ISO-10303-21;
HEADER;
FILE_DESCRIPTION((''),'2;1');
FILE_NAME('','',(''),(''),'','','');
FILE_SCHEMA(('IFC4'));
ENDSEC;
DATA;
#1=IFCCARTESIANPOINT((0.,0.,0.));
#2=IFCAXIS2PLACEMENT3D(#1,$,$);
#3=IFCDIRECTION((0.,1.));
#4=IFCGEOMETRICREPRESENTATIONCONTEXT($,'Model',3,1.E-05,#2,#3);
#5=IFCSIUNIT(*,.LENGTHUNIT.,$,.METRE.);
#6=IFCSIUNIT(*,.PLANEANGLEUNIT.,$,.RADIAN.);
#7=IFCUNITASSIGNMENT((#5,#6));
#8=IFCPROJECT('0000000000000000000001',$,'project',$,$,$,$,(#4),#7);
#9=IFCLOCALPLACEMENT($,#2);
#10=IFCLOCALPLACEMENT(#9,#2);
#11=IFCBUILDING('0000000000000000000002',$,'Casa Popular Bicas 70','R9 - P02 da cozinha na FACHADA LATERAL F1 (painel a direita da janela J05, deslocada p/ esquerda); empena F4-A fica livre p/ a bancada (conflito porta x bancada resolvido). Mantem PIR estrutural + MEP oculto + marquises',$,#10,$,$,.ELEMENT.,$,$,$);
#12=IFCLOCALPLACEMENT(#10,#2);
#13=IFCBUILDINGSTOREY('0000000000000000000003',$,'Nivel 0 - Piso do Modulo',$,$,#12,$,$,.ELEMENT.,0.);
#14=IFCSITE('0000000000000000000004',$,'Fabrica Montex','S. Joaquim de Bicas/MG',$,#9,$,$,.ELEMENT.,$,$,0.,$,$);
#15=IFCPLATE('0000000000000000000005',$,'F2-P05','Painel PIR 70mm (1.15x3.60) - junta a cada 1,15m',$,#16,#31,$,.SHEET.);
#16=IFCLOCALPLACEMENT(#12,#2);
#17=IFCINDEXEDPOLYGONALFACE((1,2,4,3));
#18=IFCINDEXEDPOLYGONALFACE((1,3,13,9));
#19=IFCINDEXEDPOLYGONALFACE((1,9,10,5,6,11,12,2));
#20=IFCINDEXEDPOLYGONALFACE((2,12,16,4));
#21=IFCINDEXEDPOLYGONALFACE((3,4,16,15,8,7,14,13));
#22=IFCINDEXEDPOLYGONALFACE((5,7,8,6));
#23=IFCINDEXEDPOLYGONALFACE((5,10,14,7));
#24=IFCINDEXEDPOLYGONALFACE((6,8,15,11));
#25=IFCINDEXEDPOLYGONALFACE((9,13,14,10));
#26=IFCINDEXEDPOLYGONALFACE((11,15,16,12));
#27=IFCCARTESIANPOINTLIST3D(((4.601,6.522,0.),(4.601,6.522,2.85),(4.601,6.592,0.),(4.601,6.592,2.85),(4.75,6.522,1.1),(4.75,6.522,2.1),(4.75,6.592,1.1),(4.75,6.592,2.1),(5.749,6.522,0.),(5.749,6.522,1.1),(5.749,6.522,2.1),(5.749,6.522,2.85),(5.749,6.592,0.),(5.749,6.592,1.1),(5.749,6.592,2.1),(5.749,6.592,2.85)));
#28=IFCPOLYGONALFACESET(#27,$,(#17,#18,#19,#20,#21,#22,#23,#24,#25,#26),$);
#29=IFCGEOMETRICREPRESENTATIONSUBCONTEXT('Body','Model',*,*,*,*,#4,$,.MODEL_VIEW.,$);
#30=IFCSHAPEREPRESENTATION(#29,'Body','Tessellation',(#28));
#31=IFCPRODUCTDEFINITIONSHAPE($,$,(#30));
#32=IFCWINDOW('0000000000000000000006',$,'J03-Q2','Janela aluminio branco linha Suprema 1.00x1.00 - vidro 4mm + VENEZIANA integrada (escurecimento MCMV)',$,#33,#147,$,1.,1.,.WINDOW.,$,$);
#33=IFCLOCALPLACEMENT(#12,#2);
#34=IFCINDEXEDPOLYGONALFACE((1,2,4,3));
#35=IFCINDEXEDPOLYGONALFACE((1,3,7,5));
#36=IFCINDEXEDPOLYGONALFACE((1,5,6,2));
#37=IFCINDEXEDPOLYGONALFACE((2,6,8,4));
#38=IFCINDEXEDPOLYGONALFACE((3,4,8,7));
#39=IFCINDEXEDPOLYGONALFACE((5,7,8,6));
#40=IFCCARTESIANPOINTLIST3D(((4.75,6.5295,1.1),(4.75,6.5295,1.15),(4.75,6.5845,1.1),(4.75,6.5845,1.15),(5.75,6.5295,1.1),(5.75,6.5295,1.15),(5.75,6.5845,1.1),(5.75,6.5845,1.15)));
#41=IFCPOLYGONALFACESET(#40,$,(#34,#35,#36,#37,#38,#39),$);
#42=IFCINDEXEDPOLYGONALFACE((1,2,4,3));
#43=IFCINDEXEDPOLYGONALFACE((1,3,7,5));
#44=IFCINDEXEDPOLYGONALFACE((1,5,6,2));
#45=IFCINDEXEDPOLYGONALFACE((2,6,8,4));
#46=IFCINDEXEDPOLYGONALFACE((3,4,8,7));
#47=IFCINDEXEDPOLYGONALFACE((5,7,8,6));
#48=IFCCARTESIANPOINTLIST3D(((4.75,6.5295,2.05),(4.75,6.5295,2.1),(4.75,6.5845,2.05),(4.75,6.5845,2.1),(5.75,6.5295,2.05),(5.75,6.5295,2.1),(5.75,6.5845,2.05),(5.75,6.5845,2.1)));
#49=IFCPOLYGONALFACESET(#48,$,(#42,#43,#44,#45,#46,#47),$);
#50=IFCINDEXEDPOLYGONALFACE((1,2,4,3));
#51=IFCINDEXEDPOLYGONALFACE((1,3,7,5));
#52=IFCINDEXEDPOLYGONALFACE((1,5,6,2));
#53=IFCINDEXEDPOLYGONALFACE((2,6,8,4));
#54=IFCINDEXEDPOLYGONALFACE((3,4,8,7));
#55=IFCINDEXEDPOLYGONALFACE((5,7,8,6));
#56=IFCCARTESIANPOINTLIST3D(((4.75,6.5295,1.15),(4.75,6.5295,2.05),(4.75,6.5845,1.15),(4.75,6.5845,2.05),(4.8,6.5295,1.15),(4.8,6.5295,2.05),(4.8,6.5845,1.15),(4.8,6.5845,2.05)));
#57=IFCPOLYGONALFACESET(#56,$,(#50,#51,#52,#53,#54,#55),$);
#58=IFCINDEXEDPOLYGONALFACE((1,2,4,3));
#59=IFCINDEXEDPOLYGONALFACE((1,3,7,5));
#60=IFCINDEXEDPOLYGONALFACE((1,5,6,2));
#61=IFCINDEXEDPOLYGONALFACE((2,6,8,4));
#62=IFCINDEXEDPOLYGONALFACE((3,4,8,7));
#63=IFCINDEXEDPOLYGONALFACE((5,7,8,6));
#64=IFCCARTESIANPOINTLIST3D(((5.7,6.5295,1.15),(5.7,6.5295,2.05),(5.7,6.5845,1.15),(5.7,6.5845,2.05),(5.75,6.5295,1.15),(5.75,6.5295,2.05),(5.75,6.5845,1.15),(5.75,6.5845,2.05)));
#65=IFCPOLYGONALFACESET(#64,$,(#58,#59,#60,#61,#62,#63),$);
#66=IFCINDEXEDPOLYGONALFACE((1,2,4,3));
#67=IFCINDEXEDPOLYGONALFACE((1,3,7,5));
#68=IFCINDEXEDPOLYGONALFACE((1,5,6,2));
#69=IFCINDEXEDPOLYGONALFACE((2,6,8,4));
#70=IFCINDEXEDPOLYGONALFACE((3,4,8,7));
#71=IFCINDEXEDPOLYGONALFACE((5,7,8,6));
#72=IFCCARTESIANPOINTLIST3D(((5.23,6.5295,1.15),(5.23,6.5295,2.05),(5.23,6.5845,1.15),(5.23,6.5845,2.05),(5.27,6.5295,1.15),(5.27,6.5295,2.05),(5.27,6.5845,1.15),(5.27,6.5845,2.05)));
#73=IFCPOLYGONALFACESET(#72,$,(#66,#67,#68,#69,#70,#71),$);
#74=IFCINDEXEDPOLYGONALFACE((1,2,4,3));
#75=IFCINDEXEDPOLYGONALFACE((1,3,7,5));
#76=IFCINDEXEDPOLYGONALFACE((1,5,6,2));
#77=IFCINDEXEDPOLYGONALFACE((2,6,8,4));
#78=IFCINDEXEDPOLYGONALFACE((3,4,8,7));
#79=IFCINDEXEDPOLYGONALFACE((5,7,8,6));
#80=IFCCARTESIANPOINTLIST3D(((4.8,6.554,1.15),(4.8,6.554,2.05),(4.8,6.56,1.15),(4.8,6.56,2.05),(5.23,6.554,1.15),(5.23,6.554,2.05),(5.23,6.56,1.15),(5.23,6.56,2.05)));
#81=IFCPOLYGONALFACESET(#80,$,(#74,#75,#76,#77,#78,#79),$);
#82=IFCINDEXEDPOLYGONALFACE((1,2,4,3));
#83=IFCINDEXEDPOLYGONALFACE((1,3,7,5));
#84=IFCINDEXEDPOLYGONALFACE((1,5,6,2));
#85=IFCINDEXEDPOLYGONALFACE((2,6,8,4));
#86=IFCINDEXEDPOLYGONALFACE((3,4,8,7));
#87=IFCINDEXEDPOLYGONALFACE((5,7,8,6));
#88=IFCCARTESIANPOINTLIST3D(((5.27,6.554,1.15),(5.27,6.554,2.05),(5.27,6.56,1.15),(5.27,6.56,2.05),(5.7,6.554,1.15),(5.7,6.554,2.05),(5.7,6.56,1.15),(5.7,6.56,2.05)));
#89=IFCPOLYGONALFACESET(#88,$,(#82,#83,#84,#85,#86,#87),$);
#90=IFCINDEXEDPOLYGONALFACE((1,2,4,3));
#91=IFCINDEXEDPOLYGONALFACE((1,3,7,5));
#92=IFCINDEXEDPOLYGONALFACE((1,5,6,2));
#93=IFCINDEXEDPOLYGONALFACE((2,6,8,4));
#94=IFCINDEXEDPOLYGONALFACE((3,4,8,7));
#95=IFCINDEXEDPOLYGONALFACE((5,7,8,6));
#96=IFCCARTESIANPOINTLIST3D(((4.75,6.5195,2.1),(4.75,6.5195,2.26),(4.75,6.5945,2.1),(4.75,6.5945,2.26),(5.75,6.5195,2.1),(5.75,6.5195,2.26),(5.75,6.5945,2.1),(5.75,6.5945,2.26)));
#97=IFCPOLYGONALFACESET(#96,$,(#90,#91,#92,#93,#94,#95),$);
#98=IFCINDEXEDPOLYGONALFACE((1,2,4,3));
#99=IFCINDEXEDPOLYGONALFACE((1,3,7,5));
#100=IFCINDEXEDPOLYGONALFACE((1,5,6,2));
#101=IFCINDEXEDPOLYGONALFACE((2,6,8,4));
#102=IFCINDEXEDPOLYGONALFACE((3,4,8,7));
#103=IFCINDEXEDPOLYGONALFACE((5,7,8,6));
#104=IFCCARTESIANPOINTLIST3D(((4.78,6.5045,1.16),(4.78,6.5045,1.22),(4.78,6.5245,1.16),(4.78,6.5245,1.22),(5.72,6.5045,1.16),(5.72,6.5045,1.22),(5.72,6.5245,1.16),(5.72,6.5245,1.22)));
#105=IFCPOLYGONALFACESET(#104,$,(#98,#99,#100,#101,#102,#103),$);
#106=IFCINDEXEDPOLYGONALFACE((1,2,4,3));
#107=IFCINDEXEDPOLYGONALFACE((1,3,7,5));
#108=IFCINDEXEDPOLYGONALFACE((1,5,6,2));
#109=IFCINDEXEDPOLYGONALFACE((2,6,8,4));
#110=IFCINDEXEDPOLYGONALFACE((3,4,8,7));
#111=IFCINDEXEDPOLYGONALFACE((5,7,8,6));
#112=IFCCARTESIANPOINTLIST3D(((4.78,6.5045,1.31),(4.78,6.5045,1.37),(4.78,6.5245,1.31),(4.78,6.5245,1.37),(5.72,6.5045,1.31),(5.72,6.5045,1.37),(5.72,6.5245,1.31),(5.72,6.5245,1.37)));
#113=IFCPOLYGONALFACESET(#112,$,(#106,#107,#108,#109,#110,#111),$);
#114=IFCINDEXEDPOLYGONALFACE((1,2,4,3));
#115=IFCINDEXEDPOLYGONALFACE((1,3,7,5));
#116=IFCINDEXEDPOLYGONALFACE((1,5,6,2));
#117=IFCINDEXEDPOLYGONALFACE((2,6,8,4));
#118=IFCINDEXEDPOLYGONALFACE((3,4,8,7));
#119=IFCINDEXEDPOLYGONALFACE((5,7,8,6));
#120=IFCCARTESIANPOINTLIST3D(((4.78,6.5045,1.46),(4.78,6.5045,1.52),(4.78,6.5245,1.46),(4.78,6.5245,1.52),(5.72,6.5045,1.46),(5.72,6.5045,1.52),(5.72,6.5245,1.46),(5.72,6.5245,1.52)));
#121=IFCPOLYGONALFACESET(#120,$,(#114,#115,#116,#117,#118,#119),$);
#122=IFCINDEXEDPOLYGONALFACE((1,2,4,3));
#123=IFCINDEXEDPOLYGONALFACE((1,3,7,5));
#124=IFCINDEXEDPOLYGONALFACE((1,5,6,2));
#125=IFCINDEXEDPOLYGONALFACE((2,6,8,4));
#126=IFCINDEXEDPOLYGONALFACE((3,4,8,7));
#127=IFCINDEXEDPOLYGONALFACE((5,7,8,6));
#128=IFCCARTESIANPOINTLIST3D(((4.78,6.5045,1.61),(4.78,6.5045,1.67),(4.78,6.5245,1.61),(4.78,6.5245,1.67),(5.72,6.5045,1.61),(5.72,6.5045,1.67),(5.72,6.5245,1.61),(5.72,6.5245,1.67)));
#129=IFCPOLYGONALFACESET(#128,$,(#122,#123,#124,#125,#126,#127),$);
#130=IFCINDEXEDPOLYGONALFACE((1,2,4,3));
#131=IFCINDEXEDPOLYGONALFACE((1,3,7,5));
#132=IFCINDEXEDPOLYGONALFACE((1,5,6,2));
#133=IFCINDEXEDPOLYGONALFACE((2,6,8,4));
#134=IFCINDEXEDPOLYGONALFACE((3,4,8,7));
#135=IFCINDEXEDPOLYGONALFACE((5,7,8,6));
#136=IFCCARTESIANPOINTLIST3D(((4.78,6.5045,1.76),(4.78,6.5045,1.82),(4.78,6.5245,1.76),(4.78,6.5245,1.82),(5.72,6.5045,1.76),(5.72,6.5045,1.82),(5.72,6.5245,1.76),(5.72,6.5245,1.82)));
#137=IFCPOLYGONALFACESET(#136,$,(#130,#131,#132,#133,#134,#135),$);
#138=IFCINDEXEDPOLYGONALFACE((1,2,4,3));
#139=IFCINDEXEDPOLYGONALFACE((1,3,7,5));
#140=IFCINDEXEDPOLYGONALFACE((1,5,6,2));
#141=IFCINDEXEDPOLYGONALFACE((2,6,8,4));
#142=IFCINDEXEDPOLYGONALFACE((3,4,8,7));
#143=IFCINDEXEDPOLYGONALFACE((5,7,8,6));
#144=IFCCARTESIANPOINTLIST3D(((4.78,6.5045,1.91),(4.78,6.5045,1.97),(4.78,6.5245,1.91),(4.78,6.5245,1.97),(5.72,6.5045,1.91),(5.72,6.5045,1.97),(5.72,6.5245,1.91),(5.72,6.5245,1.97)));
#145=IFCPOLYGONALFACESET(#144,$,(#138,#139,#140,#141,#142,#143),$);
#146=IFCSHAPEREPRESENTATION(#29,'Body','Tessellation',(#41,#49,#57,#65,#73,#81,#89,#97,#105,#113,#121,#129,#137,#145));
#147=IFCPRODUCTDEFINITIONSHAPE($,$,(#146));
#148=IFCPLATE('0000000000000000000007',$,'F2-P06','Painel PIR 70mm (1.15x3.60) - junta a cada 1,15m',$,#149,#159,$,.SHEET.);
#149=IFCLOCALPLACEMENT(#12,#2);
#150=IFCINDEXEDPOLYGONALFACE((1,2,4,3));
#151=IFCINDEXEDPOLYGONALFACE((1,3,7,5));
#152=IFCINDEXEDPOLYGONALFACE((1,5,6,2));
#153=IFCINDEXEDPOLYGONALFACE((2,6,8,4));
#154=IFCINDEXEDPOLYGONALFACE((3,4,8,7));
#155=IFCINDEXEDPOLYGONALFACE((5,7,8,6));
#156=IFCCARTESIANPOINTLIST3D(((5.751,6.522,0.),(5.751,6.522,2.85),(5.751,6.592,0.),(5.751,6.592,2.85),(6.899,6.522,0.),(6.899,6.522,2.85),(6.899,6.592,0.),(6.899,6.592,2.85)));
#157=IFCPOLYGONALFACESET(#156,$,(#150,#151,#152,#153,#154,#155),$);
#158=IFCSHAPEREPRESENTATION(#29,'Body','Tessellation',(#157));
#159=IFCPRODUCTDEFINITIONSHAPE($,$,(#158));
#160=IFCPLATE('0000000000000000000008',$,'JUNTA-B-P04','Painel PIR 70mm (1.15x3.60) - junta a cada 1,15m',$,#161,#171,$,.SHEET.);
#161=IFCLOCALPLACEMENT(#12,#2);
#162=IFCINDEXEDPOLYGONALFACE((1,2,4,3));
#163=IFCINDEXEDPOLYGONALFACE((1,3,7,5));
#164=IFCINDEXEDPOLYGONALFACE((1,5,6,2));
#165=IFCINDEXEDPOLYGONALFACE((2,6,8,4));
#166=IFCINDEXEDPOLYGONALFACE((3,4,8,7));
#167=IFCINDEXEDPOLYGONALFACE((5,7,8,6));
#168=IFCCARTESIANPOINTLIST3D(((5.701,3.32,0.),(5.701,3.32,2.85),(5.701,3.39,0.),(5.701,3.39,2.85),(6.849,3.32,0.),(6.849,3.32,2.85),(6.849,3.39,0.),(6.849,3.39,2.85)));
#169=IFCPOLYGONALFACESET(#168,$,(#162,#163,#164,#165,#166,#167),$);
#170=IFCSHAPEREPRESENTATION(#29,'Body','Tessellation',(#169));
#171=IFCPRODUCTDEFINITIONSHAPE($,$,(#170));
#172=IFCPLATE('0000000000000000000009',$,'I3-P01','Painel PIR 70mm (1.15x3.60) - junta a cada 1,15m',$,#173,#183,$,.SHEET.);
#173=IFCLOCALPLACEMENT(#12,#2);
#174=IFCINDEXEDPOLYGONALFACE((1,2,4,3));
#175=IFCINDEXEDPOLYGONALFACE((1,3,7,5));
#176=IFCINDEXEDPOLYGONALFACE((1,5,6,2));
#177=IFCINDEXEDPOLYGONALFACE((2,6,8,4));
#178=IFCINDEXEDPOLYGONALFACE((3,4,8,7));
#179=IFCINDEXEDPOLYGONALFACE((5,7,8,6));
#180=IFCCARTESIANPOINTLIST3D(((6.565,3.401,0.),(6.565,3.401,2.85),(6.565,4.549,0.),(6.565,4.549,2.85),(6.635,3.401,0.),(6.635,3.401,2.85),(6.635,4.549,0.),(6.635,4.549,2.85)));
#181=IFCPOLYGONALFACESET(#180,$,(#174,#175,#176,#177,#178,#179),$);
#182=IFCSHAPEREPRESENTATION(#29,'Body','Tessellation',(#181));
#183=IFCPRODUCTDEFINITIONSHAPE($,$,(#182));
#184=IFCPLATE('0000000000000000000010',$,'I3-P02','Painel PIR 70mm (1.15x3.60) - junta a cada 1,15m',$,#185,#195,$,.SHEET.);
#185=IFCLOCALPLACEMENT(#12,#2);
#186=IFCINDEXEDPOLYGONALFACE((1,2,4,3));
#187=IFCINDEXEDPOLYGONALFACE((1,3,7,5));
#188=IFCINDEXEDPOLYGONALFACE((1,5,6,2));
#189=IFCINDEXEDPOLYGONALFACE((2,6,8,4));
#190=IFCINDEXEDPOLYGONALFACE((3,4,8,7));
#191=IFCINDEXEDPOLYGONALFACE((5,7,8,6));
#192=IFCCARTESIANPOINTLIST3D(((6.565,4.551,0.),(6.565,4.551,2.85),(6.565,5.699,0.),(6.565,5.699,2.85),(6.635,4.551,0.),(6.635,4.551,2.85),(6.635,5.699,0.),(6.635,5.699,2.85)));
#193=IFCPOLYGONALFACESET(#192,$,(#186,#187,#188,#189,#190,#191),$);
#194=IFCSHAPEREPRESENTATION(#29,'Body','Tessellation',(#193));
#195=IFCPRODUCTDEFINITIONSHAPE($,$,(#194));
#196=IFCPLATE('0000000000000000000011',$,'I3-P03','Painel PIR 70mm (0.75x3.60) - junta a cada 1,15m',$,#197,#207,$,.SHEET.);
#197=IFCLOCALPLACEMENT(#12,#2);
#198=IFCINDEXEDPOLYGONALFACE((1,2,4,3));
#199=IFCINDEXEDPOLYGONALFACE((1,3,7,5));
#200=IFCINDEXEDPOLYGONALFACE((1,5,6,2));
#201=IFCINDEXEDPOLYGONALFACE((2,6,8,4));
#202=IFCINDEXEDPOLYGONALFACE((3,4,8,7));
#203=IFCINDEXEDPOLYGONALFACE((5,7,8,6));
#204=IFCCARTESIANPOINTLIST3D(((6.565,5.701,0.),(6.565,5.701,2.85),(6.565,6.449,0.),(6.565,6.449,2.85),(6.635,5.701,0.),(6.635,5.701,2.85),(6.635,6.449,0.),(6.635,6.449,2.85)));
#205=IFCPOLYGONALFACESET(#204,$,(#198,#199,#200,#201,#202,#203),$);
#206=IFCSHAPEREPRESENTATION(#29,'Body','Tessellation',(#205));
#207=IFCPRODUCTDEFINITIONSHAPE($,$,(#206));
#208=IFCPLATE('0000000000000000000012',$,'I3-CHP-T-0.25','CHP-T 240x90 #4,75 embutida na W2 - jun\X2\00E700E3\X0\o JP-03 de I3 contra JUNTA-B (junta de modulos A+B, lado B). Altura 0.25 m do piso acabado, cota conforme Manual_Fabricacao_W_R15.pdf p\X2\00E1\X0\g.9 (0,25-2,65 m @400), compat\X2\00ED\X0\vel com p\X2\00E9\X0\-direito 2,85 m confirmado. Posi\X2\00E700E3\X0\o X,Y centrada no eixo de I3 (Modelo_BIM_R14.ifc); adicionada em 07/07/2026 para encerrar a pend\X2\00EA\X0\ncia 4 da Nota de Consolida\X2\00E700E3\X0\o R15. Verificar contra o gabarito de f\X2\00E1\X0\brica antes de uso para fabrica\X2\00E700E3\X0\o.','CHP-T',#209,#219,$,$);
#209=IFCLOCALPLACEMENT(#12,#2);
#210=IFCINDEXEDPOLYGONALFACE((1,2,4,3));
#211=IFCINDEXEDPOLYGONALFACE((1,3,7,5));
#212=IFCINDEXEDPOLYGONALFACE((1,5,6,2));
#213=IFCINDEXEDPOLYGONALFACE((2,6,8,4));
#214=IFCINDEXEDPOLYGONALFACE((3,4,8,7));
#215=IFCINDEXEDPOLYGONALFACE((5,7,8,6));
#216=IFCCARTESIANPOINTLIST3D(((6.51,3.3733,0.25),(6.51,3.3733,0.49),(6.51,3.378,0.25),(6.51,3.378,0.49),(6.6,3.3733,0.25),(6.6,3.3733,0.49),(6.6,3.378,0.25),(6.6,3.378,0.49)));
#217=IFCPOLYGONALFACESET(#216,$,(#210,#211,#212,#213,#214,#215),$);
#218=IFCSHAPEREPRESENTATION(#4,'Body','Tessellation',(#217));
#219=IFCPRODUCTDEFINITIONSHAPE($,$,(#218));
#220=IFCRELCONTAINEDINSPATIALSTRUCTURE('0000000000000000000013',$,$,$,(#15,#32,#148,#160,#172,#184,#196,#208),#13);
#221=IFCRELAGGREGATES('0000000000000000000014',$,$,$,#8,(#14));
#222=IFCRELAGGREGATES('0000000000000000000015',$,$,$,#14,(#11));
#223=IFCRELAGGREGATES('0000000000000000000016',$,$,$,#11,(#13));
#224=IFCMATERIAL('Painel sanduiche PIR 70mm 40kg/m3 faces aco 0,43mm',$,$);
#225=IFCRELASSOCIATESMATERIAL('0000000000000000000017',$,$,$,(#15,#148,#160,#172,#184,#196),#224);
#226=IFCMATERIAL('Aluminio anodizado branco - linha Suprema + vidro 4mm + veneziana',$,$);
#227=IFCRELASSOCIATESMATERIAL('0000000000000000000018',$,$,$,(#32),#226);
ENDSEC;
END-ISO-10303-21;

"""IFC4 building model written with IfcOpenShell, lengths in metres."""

from ifc_helpers import new_model, si_unit, direction, frame, frame_2d, origin, origin_with_axes, origin_2d, place, context, subcontext, project, spatial, rectangle, extrude, material, element, fill, save


model = new_model("IFC4")

# Units and contexts
model_context = context("Model", 3, precision=1e-05, world=origin(), true_north=direction((0.0, 1.0)))
body_context = subcontext(model_context, "Body", "Model", "MODEL_VIEW")
ifc_project = project(units=[si_unit("LENGTHUNIT", "METRE"), si_unit("PLANEANGLEUNIT", "RADIAN")], contexts=[model_context])

# Site, building, storey
site_placement = place(None, origin())
site = spatial("IfcSite", under=ifc_project, at=site_placement, Name="Fabrica Montex", Description="S. Joaquim de Bicas/MG", CompositionType="ELEMENT", RefElevation=0.0)
building_placement = place(site_placement, origin())
building = spatial("IfcBuilding", under=site, at=building_placement, Name="Casa Popular Bicas 70", Description="R9 - P02 da cozinha na FACHADA LATERAL F1 (painel a direita da janela J05, deslocada p/ esquerda); empena F4-A fica livre p/ a bancada (conflito porta x bancada resolvido). Mantem PIR estrutural + MEP oculto + marquises", CompositionType="ELEMENT")
storey_placement = place(building_placement, origin())
storey = spatial("IfcBuildingStorey", under=building, at=storey_placement, Name="Nivel 0 - Piso do Modulo", CompositionType="ELEMENT", Elevation=0.0)

# Plate, opening, window
ifc_material_1 = material(Name="Painel sanduiche PIR 70mm 40kg/m3 faces aco 0,43mm")
plate_1_placement = place(storey_placement, frame((4.601, 6.557, 0.0), x_axis=(1.0, 0.0, 0.0)))
plate_1 = element("IfcPlate", 1, at=plate_1_placement, inside=storey, material=ifc_material_1, Name="F2-P05", Description="Painel PIR 70mm (1.15x3.60) - junta a cada 1,15m", PredefinedType="SHEET", context=body_context, shape_type="SweptSolid", body=[
    extrude(rectangle(XDim=1.148, YDim=0.07, at=frame_2d((0.574, 0.0))), origin(), (0.0, 0.0, 1.0), 2.85),
])
opening_1_placement = place(storey_placement, frame((5.25, 6.557, 1.1)))
opening_1 = element("IfcOpeningElement", 2, at=opening_1_placement, cuts=plate_1, PredefinedType="OPENING", context=body_context, shape_type="SweptSolid", body=[
    extrude(rectangle(XDim=1.0, YDim=0.1, at=origin_2d()), origin(), (0.0, 0.0, 1.0), 1.0),
])
ifc_material_2 = material(Name="Aluminio anodizado branco - linha Suprema + vidro 4mm + veneziana")
window_placement = place(storey_placement, frame((4.75, 6.557, 1.1), x_axis=(1.0, 0.0, 0.0)))
window = element("IfcWindow", 3, at=window_placement, inside=storey, material=ifc_material_2, Name="J03-Q2", Description="Janela aluminio branco linha Suprema 1.00x1.00 - vidro 4mm + VENEZIANA integrada (escurecimento MCMV)", OverallHeight=1.0, OverallWidth=1.0, PredefinedType="WINDOW", context=body_context, shape_type="SweptSolid", body=[
    extrude(rectangle(XDim=1.0, YDim=0.055, at=frame_2d((0.5, 0.0))), origin(), (0.0, 0.0, 1.0), 0.05),
    extrude(rectangle(XDim=1.0, YDim=0.055, at=frame_2d((0.5, 0.0))), frame((0.0, 0.0, 0.95)), (0.0, 0.0, 1.0), 0.05),
    extrude(rectangle(XDim=0.05, YDim=0.055, at=frame_2d((0.025, 0.0))), frame((0.0, 0.0, 0.05)), (0.0, 0.0, 1.0), 0.9),
    extrude(rectangle(XDim=0.05, YDim=0.055, at=frame_2d((0.975, 0.0))), frame((0.0, 0.0, 0.05)), (0.0, 0.0, 1.0), 0.9),
    extrude(rectangle(XDim=0.04, YDim=0.055, at=frame_2d((0.5, 0.0))), frame((0.0, 0.0, 0.05)), (0.0, 0.0, 1.0), 0.9),
    extrude(rectangle(XDim=0.43, YDim=0.006, at=frame_2d((0.265, 0.0))), frame((0.0, 0.0, 0.05)), (0.0, 0.0, 1.0), 0.9),
    extrude(rectangle(XDim=0.43, YDim=0.006, at=frame_2d((0.735, 0.0))), frame((0.0, 0.0, 0.05)), (0.0, 0.0, 1.0), 0.9),
    extrude(rectangle(XDim=1.0, YDim=0.075, at=frame_2d((0.5, 0.0))), frame((0.0, 0.0, 1.0)), (0.0, 0.0, 1.0), 0.16),
    extrude(rectangle(XDim=0.94, YDim=0.02, at=frame_2d((0.5, -0.0425))), frame((0.0, 0.0, 0.06)), (0.0, 0.0, 1.0), 0.06),
    extrude(rectangle(XDim=0.94, YDim=0.02, at=frame_2d((0.5, -0.0425))), frame((0.0, 0.0, 0.21)), (0.0, 0.0, 1.0), 0.06),
    extrude(rectangle(XDim=0.94, YDim=0.02, at=frame_2d((0.5, -0.0425))), frame((0.0, 0.0, 0.36)), (0.0, 0.0, 1.0), 0.06),
    extrude(rectangle(XDim=0.94, YDim=0.02, at=frame_2d((0.5, -0.0425))), frame((0.0, 0.0, 0.51)), (0.0, 0.0, 1.0), 0.06),
    extrude(rectangle(XDim=0.94, YDim=0.02, at=frame_2d((0.5, -0.0425))), frame((0.0, 0.0, 0.66)), (0.0, 0.0, 1.0), 0.06),
    extrude(rectangle(XDim=0.94, YDim=0.02, at=frame_2d((0.5, -0.0425))), frame((0.0, 0.0, 0.81)), (0.0, 0.0, 1.0), 0.06),
])
fill(opening_1, window)

# Plates
for number, where, x_axis, name in (
    (4, (5.751, 6.557, 0.0), (1.0, 0.0, 0.0), "F2-P06"),
    (5, (5.701, 3.355, 0.0), (1.0, 0.0, 0.0), "JUNTA-B-P04"),
    (6, (6.6, 3.401, 0.0), (0.0, 1.0, 0.0), "I3-P01"),
    (7, (6.6, 4.551, 0.0), (0.0, 1.0, 0.0), "I3-P02"),
):
    element("IfcPlate", number, at=place(storey_placement, frame(where, x_axis=x_axis)), inside=storey, material=ifc_material_1, Name=name, Description="Painel PIR 70mm (1.15x3.60) - junta a cada 1,15m", PredefinedType="SHEET", context=body_context, shape_type="SweptSolid", body=[
        extrude(rectangle(XDim=1.148, YDim=0.07, at=frame_2d((0.574, 0.0))), origin(), (0.0, 0.0, 1.0), 2.85),
    ])
plate_2_placement = place(storey_placement, frame((6.6, 5.701, 0.0), x_axis=(0.0, 1.0, 0.0)))
element("IfcPlate", 8, at=plate_2_placement, inside=storey, material=ifc_material_1, Name="I3-P03", Description="Painel PIR 70mm (0.75x3.60) - junta a cada 1,15m", PredefinedType="SHEET", context=body_context, shape_type="SweptSolid", body=[
    extrude(rectangle(XDim=0.748, YDim=0.07, at=frame_2d((0.374, 0.0))), origin(), (0.0, 0.0, 1.0), 2.85),
])
for number, where, z_axis, x_axis, name in (
    (9, (6.555, 3.3756, 0.25), (0.0, 0.0, 1.0), (1.0, 0.0, 0.0), "I3-CHP-T-0.25"),
):
    element("IfcPlate", number, at=place(storey_placement, frame(where, z_axis=z_axis, x_axis=x_axis)), inside=storey, Name=name, Description="CHP-T 240x90 #4,75 embutida na W2 - junção JP-03 de I3 contra JUNTA-B (junta de modulos A+B, lado B). Altura 0.25 m do piso acabado, cota conforme Manual_Fabricacao_W_R15.pdf pág.9 (0,25-2,65 m @400), compatível com pé-direito 2,85 m confirmado. Posição X,Y centrada no eixo de I3 (Modelo_BIM_R14.ifc); adicionada em 07/07/2026 para encerrar a pendência 4 da Nota de Consolidação R15. Verificar contra o gabarito de fábrica antes de uso para fabricação.", ObjectType="CHP-T", context=model_context, shape_type="SweptSolid", body=[
        extrude(rectangle(XDim=0.09, YDim=0.0047, at=origin_2d()), origin_with_axes(), (0.0, 0.0, 1.0), 0.24),
    ])

save(model, "model.ifc")
